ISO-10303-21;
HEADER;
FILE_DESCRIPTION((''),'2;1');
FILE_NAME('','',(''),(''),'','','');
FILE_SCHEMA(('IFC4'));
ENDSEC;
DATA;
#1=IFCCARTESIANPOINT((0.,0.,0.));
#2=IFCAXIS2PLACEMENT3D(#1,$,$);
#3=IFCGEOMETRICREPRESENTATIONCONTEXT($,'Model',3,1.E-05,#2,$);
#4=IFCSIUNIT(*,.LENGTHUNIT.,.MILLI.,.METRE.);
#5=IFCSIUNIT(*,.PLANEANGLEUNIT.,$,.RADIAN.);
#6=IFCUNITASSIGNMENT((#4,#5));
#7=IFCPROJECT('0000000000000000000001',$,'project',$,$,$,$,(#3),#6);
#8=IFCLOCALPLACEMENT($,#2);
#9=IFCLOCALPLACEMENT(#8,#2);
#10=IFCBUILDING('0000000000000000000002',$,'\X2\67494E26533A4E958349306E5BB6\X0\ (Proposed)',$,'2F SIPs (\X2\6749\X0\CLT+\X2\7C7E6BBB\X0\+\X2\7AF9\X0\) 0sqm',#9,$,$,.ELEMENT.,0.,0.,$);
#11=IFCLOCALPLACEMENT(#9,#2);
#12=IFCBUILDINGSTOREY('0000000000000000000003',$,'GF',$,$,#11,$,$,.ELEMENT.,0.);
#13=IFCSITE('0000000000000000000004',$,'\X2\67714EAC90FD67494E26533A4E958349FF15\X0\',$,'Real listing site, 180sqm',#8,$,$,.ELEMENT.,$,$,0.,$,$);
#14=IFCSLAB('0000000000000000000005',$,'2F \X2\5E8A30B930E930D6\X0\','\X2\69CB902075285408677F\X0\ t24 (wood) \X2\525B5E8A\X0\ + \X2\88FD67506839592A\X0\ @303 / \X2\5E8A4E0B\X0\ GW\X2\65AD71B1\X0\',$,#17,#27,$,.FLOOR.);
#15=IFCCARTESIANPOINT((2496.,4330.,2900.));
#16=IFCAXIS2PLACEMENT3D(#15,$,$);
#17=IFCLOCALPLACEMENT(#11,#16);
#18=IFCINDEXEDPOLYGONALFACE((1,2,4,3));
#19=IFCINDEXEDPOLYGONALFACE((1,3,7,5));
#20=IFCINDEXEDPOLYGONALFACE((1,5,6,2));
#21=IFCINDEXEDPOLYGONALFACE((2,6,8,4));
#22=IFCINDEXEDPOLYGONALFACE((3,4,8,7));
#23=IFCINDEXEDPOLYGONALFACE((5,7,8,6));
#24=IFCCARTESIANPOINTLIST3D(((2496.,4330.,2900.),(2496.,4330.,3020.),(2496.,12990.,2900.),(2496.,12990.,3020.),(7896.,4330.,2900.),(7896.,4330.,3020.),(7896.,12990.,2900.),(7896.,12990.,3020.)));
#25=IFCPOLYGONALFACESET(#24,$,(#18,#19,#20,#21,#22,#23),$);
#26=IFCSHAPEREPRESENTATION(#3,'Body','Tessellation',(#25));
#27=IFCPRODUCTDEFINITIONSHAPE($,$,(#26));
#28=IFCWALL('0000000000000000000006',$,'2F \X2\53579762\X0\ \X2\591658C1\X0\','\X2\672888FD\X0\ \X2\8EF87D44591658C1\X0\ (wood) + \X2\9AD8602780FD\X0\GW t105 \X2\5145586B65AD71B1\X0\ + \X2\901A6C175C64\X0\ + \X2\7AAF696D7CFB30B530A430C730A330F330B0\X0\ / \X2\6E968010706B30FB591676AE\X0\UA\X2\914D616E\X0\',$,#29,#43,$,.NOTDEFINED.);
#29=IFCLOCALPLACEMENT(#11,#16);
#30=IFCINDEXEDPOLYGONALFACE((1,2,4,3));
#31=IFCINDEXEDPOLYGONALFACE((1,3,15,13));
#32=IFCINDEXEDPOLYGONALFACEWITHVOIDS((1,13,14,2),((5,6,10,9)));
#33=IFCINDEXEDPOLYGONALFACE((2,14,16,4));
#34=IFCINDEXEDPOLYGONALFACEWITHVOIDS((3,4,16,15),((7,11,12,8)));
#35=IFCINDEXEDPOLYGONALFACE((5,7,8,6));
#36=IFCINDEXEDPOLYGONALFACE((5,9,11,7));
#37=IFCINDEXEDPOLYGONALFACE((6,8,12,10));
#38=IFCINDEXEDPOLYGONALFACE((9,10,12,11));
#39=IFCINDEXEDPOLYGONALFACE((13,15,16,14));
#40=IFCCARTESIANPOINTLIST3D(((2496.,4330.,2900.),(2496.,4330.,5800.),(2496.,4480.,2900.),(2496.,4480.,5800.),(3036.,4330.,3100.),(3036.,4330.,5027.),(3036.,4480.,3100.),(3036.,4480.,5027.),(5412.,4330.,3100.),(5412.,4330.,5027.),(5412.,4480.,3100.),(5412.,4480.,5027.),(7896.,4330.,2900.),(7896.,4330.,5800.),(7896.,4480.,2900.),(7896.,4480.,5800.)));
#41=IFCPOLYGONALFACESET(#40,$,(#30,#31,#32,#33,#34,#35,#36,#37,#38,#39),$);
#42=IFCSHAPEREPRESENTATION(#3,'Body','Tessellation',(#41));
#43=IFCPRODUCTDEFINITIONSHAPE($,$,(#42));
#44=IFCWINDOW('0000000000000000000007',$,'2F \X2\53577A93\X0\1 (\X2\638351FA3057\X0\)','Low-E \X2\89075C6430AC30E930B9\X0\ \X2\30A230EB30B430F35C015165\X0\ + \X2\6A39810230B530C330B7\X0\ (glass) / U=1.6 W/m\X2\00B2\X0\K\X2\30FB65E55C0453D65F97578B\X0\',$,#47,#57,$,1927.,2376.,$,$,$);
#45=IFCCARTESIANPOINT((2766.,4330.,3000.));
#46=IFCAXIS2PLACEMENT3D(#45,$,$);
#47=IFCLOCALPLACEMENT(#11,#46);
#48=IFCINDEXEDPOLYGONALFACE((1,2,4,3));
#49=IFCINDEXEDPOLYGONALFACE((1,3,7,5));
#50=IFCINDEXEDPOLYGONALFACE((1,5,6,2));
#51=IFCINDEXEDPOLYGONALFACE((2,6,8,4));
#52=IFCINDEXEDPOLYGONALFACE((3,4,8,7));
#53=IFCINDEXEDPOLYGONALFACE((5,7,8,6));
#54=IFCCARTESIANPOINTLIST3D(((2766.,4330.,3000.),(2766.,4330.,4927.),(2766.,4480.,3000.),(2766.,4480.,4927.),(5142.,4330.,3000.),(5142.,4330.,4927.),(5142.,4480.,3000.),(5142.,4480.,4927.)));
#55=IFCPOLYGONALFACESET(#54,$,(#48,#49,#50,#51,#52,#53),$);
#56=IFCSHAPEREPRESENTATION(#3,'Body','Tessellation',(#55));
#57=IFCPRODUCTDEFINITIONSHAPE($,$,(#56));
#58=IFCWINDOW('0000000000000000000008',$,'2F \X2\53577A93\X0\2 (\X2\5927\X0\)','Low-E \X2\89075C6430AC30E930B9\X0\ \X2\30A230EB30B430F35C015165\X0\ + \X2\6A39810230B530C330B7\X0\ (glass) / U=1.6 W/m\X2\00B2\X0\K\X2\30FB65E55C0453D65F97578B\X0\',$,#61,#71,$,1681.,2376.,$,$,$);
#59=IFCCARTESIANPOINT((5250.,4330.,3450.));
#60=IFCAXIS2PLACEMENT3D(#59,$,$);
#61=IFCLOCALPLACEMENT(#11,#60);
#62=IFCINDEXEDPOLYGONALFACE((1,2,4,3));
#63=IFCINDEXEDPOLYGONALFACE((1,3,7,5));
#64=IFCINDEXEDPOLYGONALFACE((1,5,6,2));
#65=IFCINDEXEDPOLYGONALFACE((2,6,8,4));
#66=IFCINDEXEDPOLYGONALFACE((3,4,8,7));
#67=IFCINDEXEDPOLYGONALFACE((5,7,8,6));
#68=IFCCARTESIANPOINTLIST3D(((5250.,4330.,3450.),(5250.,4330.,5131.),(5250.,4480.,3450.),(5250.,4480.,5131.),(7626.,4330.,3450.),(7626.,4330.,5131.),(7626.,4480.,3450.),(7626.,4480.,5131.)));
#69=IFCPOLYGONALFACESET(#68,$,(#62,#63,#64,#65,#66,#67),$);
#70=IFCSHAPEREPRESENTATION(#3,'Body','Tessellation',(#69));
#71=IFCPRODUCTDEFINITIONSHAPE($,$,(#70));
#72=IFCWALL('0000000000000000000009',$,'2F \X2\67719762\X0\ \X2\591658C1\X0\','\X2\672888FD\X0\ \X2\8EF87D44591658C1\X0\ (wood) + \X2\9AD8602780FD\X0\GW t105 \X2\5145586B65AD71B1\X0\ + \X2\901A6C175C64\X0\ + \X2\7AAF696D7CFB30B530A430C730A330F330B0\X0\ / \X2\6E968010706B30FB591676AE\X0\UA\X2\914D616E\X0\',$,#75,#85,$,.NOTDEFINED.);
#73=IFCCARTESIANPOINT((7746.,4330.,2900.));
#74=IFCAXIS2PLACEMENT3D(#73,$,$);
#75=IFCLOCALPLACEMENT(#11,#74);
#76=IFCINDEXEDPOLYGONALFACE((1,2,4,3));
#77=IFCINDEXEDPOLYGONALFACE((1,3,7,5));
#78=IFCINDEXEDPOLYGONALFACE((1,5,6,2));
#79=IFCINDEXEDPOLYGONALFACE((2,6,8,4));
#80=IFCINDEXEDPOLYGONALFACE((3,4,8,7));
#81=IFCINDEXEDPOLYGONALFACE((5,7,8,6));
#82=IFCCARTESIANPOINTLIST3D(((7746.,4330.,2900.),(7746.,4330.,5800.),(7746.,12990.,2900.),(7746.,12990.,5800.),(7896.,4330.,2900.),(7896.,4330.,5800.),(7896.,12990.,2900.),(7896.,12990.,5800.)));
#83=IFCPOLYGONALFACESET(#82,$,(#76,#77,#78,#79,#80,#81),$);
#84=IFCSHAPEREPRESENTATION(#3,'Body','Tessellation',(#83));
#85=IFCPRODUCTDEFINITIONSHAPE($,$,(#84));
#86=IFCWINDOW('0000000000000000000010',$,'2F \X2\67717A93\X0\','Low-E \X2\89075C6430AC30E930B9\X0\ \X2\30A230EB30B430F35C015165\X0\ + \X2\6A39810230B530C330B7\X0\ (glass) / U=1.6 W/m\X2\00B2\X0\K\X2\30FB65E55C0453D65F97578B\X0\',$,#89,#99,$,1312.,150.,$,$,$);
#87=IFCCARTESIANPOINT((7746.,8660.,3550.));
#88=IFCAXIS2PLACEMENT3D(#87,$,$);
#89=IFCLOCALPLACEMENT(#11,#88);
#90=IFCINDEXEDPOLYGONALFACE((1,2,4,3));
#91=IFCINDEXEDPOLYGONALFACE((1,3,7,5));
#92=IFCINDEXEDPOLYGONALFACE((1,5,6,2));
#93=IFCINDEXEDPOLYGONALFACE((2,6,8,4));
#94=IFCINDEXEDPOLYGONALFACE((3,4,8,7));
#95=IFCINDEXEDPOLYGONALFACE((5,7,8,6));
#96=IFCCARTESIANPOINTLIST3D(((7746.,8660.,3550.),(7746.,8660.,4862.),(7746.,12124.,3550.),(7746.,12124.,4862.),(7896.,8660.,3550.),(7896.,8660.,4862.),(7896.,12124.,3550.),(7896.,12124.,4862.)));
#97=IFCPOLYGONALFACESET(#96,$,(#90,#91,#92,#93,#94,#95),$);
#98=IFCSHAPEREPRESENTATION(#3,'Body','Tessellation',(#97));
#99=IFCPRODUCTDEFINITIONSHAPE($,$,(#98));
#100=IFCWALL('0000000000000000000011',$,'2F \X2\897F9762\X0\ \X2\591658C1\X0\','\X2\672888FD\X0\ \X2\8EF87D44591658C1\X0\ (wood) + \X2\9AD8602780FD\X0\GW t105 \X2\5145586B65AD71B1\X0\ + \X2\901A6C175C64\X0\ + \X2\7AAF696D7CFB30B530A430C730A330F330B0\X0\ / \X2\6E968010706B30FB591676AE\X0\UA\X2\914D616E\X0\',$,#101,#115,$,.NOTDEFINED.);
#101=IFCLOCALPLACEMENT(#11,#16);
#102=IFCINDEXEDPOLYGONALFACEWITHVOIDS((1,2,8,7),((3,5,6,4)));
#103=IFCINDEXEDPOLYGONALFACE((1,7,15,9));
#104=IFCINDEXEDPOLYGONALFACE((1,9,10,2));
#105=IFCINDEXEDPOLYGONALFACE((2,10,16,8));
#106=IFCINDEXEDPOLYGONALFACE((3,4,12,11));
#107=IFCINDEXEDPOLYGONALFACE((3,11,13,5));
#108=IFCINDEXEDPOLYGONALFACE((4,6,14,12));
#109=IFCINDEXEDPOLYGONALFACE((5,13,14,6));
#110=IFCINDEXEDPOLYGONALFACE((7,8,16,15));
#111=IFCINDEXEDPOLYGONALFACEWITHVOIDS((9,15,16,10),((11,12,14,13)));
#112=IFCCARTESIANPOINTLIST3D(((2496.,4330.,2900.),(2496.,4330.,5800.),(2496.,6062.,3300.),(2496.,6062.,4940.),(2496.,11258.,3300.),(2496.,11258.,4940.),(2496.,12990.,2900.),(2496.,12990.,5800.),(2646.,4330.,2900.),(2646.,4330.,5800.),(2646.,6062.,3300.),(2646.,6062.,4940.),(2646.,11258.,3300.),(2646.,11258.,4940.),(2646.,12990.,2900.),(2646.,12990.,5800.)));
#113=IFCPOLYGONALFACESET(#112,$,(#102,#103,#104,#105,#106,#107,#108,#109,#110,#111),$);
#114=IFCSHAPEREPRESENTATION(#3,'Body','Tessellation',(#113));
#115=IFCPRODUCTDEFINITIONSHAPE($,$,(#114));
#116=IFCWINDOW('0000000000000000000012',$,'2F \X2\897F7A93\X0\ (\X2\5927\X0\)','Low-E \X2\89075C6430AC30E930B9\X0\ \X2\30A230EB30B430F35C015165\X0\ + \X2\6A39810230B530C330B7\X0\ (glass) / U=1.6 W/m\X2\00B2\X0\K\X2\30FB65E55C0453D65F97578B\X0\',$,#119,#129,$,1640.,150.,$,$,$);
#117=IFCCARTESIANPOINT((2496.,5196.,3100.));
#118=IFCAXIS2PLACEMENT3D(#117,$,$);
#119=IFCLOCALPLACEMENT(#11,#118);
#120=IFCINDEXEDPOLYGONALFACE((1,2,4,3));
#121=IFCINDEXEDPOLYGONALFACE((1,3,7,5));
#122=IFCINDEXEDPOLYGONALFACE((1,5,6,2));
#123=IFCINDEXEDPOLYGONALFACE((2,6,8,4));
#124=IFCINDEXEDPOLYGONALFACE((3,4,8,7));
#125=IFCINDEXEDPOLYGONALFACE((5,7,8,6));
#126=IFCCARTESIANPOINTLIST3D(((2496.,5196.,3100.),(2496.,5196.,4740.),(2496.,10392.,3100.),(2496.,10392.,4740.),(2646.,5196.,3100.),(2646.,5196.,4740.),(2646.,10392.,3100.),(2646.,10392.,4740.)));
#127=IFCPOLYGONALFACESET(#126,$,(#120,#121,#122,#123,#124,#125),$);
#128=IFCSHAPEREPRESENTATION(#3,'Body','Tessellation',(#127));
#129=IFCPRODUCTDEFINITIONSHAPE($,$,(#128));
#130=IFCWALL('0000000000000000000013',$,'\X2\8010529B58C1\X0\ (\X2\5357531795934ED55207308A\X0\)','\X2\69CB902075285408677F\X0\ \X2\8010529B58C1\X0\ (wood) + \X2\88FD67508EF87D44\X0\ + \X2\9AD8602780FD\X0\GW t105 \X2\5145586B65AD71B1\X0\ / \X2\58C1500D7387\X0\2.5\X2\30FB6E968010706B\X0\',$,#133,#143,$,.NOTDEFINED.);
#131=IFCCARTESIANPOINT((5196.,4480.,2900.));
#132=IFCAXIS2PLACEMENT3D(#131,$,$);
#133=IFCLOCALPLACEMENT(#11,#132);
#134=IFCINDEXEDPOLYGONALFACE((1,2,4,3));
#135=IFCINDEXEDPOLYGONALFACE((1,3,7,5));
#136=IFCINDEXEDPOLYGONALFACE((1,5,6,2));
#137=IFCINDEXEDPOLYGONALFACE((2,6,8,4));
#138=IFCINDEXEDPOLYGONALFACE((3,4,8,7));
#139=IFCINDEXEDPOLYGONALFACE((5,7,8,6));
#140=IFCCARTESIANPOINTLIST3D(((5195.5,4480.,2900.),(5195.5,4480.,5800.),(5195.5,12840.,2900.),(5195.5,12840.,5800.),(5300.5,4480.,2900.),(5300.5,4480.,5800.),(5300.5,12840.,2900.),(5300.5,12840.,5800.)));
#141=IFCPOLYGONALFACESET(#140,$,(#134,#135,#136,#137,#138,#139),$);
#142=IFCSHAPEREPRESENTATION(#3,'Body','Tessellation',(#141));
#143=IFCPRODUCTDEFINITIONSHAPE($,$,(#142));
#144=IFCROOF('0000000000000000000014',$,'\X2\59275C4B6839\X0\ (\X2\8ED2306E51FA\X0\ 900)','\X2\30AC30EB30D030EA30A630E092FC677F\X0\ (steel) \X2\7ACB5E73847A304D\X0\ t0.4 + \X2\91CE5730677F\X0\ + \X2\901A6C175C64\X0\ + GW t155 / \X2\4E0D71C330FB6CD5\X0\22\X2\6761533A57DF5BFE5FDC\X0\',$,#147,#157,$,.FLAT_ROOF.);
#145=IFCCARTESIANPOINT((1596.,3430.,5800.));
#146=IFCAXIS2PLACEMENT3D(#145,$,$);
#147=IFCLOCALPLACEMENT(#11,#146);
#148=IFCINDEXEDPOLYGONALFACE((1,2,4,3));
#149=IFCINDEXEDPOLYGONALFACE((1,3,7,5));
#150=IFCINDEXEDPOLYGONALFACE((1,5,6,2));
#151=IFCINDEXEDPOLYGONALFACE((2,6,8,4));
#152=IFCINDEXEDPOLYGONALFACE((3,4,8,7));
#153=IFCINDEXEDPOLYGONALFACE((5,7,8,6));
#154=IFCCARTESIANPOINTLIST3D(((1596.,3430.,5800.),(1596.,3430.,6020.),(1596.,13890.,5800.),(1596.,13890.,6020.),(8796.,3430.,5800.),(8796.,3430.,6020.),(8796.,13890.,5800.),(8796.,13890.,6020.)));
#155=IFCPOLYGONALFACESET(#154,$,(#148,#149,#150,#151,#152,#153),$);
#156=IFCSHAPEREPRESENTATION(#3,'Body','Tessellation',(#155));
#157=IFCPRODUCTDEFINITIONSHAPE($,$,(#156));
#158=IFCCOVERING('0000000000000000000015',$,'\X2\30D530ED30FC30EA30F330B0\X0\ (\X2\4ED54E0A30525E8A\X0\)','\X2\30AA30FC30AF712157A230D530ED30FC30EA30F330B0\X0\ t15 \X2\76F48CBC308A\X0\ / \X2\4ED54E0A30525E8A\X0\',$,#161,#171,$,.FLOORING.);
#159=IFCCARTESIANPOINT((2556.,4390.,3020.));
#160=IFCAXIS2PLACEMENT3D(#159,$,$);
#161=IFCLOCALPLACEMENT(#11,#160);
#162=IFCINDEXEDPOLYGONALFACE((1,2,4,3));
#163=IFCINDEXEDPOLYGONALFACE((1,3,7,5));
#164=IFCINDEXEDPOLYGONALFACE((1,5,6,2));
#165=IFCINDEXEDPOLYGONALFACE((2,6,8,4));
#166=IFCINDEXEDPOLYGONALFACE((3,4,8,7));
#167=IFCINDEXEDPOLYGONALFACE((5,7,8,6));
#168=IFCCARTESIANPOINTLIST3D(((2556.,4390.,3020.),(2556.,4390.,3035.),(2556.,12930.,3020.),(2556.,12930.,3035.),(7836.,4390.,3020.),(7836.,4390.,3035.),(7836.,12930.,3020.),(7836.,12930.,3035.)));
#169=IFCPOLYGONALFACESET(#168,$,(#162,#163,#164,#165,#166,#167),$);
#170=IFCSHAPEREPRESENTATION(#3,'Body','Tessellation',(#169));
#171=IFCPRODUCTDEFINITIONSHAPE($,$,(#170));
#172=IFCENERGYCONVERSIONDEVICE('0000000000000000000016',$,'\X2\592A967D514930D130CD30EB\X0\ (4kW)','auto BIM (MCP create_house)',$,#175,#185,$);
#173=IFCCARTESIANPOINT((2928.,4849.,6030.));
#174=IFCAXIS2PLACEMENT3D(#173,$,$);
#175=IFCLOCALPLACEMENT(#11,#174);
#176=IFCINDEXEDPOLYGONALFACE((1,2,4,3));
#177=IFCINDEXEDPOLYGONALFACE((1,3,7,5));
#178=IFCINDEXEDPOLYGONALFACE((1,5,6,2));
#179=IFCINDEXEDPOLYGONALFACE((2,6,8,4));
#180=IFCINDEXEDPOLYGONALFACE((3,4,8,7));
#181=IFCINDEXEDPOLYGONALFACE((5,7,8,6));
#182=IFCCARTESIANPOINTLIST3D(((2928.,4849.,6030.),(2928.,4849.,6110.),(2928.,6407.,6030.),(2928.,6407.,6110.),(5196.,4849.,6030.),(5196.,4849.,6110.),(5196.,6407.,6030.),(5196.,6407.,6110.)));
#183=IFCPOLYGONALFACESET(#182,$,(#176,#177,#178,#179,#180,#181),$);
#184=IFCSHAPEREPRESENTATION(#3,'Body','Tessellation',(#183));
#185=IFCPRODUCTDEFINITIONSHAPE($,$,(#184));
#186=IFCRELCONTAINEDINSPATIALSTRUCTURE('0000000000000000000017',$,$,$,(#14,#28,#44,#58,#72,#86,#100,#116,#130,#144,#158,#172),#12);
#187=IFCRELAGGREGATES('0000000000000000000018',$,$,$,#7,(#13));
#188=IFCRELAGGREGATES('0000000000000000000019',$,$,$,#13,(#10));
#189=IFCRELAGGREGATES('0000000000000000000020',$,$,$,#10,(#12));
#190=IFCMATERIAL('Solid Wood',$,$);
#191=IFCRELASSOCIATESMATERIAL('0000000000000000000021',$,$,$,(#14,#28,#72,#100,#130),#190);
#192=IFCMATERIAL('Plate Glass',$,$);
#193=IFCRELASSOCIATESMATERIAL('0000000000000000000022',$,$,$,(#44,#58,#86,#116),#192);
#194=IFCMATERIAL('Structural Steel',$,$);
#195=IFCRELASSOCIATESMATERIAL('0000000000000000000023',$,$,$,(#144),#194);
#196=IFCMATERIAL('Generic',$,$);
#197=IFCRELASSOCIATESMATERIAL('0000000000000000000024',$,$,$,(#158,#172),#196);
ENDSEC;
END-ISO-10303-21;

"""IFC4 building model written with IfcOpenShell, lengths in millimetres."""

from ifc_helpers import new_model, si_unit, frame, frame_2d, origin, place, context, project, spatial, rectangle, extrude, material, element, fill, save


model = new_model("IFC4")

# Units and contexts
model_context = context("Model", 3, precision=1e-05, world=origin())
ifc_project = project(units=[si_unit("LENGTHUNIT", "METRE", prefix="MILLI"), si_unit("PLANEANGLEUNIT", "RADIAN")], contexts=[model_context])

# Site, building, storey
site_placement = place(None, origin())
site = spatial("IfcSite", under=ifc_project, at=site_placement, Name="東京都杉並区井草５", ObjectType="Real listing site, 180sqm", CompositionType="ELEMENT", RefElevation=0.0)
building_placement = place(site_placement, origin())
building = spatial("IfcBuilding", under=site, at=building_placement, Name="杉並区井草の家 (Proposed)", ObjectType="2F SIPs (杉CLT+籾殻+竹) 0sqm", CompositionType="ELEMENT", ElevationOfRefHeight=0.0, ElevationOfTerrain=0.0)
storey_placement = place(building_placement, origin())
storey = spatial("IfcBuildingStorey", under=building, at=storey_placement, Name="GF", CompositionType="ELEMENT", Elevation=0.0)

# Slab
ifc_material_1 = material(Name="Solid Wood")
slab_placement = place(storey_placement, frame((2496.0, 4330.0, 2900.0)))
element("IfcSlab", 1, at=slab_placement, inside=storey, material=ifc_material_1, Name="2F 床スラブ", Description="構造用合板 t24 (wood) 剛床 + 製材根太 @303 / 床下 GW断熱", PredefinedType="FLOOR", context=model_context, shape_type="SweptSolid", body=[
    extrude(rectangle(XDim=5400.0, YDim=8660.0, at=frame_2d((2700.0, 4330.0))), frame((2496.0, 4330.0, 2900.0)), (0.0, 0.0, 1.0), 120.0),
])

# Wall, openings, windows
wall_1_placement = place(storey_placement, frame((2496.0, 4330.0, 2900.0)))
wall_1 = element("IfcWall", 2, at=wall_1_placement, inside=storey, material=ifc_material_1, Name="2F 南面 外壁", Description="木製 軸組外壁 (wood) + 高性能GW t105 充填断熱 + 通気層 + 窯業系サイディング / 準耐火・外皮UA配慮", PredefinedType="NOTDEFINED", context=model_context, shape_type="SweptSolid", body=[
    extrude(rectangle(XDim=5400.0, YDim=150.0, at=frame_2d((2700.0, 75.0))), frame((2496.0, 4330.0, 2900.0)), (0.0, 0.0, 1.0), 2900.0),
])
opening_1_placement = place(storey_placement, frame((2766.0, 4330.0, 3000.0)))
opening_1 = element("IfcOpeningElement", 3, at=opening_1_placement, cuts=wall_1, PredefinedType="NOTDEFINED", context=model_context, shape_type="SweptSolid", body=[
    extrude(rectangle(XDim=2376.0, YDim=150.0, at=frame_2d((1188.0, 75.0))), frame((2766.0, 4330.0, 3000.0)), (0.0, 0.0, 1.0), 1927.0),
])
opening_2_placement = place(storey_placement, frame((5250.0, 4330.0, 3450.0)))
opening_2 = element("IfcOpeningElement", 4, at=opening_2_placement, cuts=wall_1, PredefinedType="NOTDEFINED", context=model_context, shape_type="SweptSolid", body=[
    extrude(rectangle(XDim=2376.0, YDim=150.0, at=frame_2d((1188.0, 75.0))), frame((5250.0, 4330.0, 3450.0)), (0.0, 0.0, 1.0), 1681.0),
])
ifc_material_2 = material(Name="Plate Glass")
window_1_placement = place(storey_placement, frame((2766.0, 4330.0, 3000.0)))
window_1 = element("IfcWindow", 5, at=window_1_placement, inside=storey, material=ifc_material_2, Name="2F 南窓1 (掃出し)", Description="Low-E 複層ガラス アルゴン封入 + 樹脂サッシ (glass) / U=1.6 W/m²K・日射取得型", OverallHeight=1927.0, OverallWidth=2376.0, context=model_context, shape_type="SweptSolid", body=[
    extrude(rectangle(XDim=2376.0, YDim=150.0, at=frame_2d((1188.0, 75.0))), frame((2766.0, 4330.0, 3000.0)), (0.0, 0.0, 1.0), 1927.0),
])
fill(opening_1, window_1)
window_2_placement = place(storey_placement, frame((5250.0, 4330.0, 3450.0)))
window_2 = element("IfcWindow", 6, at=window_2_placement, inside=storey, material=ifc_material_2, Name="2F 南窓2 (大)", Description="Low-E 複層ガラス アルゴン封入 + 樹脂サッシ (glass) / U=1.6 W/m²K・日射取得型", OverallHeight=1681.0, OverallWidth=2376.0, context=model_context, shape_type="SweptSolid", body=[
    extrude(rectangle(XDim=2376.0, YDim=150.0, at=frame_2d((1188.0, 75.0))), frame((5250.0, 4330.0, 3450.0)), (0.0, 0.0, 1.0), 1681.0),
])
fill(opening_2, window_2)

# Walls, openings, windows
wall_2_placement = place(storey_placement, frame((7746.0, 4330.0, 2900.0)))
wall_2 = element("IfcWall", 7, at=wall_2_placement, inside=storey, material=ifc_material_1, Name="2F 東面 外壁", Description="木製 軸組外壁 (wood) + 高性能GW t105 充填断熱 + 通気層 + 窯業系サイディング / 準耐火・外皮UA配慮", PredefinedType="NOTDEFINED", context=model_context, shape_type="SweptSolid", body=[
    extrude(rectangle(XDim=150.0, YDim=8660.0, at=frame_2d((75.0, 4330.0))), frame((7746.0, 4330.0, 2900.0)), (0.0, 0.0, 1.0), 2900.0),
])
opening_3_placement = place(storey_placement, frame((7746.0, 8660.0, 3550.0)))
opening_3 = element("IfcOpeningElement", 8, at=opening_3_placement, cuts=wall_2, PredefinedType="NOTDEFINED", context=model_context, shape_type="SweptSolid", body=[
    extrude(rectangle(XDim=150.0, YDim=3464.0, at=frame_2d((75.0, 1732.0))), frame((7746.0, 8660.0, 3550.0)), (0.0, 0.0, 1.0), 1312.0),
])
window_3_placement = place(storey_placement, frame((7746.0, 8660.0, 3550.0)))
window_3 = element("IfcWindow", 9, at=window_3_placement, inside=storey, material=ifc_material_2, Name="2F 東窓", Description="Low-E 複層ガラス アルゴン封入 + 樹脂サッシ (glass) / U=1.6 W/m²K・日射取得型", OverallHeight=1312.0, OverallWidth=150.0, context=model_context, shape_type="SweptSolid", body=[
    extrude(rectangle(XDim=150.0, YDim=3464.0, at=frame_2d((75.0, 1732.0))), frame((7746.0, 8660.0, 3550.0)), (0.0, 0.0, 1.0), 1312.0),
])
fill(opening_3, window_3)
wall_3_placement = place(storey_placement, frame((2496.0, 4330.0, 2900.0)))
wall_3 = element("IfcWall", 10, at=wall_3_placement, inside=storey, material=ifc_material_1, Name="2F 西面 外壁", Description="木製 軸組外壁 (wood) + 高性能GW t105 充填断熱 + 通気層 + 窯業系サイディング / 準耐火・外皮UA配慮", PredefinedType="NOTDEFINED", context=model_context, shape_type="SweptSolid", body=[
    extrude(rectangle(XDim=150.0, YDim=8660.0, at=frame_2d((75.0, 4330.0))), frame((2496.0, 4330.0, 2900.0)), (0.0, 0.0, 1.0), 2900.0),
])
opening_4_placement = place(storey_placement, frame((2496.0, 5196.0, 3100.0)))
opening_4 = element("IfcOpeningElement", 11, at=opening_4_placement, cuts=wall_3, PredefinedType="NOTDEFINED", context=model_context, shape_type="SweptSolid", body=[
    extrude(rectangle(XDim=150.0, YDim=5196.0, at=frame_2d((75.0, 2598.0))), frame((2496.0, 5196.0, 3100.0)), (0.0, 0.0, 1.0), 1640.0),
])
window_4_placement = place(storey_placement, frame((2496.0, 5196.0, 3100.0)))
window_4 = element("IfcWindow", 12, at=window_4_placement, inside=storey, material=ifc_material_2, Name="2F 西窓 (大)", Description="Low-E 複層ガラス アルゴン封入 + 樹脂サッシ (glass) / U=1.6 W/m²K・日射取得型", OverallHeight=1640.0, OverallWidth=150.0, context=model_context, shape_type="SweptSolid", body=[
    extrude(rectangle(XDim=150.0, YDim=5196.0, at=frame_2d((75.0, 2598.0))), frame((2496.0, 5196.0, 3100.0)), (0.0, 0.0, 1.0), 1640.0),
])
fill(opening_4, window_4)

# Wall
wall_4_placement = place(storey_placement, frame((5196.0, 4480.0, 2900.0)))
element("IfcWall", 13, at=wall_4_placement, inside=storey, material=ifc_material_1, Name="耐力壁 (南北間仕切り)", Description="構造用合板 耐力壁 (wood) + 製材軸組 + 高性能GW t105 充填断熱 / 壁倍率2.5・準耐火", PredefinedType="NOTDEFINED", context=model_context, shape_type="SweptSolid", body=[
    extrude(rectangle(XDim=105.0, YDim=8360.0, at=frame_2d((52.0, 4180.0))), frame((5196.0, 4480.0, 2900.0)), (0.0, 0.0, 1.0), 2900.0),
])

# Roof
ifc_material_3 = material(Name="Structural Steel")
roof_placement = place(storey_placement, frame((1596.0, 3430.0, 5800.0)))
element("IfcRoof", 14, at=roof_placement, inside=storey, material=ifc_material_3, Name="大屋根 (軒の出 900)", Description="ガルバリウム鋼板 (steel) 立平葺き t0.4 + 野地板 + 通気層 + GW t155 / 不燃・法22条区域対応", PredefinedType="FLAT_ROOF", context=model_context, shape_type="SweptSolid", body=[
    extrude(rectangle(XDim=7200.0, YDim=10460.0, at=frame_2d((3600.0, 5230.0))), frame((1596.0, 3430.0, 5800.0)), (0.0, 0.0, 1.0), 220.0),
])

# Covering
ifc_material_4 = material(Name="Generic")
covering_placement = place(storey_placement, frame((2556.0, 4390.0, 3020.0)))
element("IfcCovering", 15, at=covering_placement, inside=storey, material=ifc_material_4, Name="フローリング (仕上げ床)", Description="オーク無垢フローリング t15 直貼り / 仕上げ床", PredefinedType="FLOORING", context=model_context, shape_type="SweptSolid", body=[
    extrude(rectangle(XDim=5280.0, YDim=8540.0, at=frame_2d((2640.0, 4270.0))), frame((2556.0, 4390.0, 3020.0)), (0.0, 0.0, 1.0), 15.0),
])

# Energy conversion device
energy_conversion_device_placement = place(storey_placement, frame((2928.0, 4849.0, 6030.0)))
element("IfcEnergyConversionDevice", 16, at=energy_conversion_device_placement, inside=storey, material=ifc_material_4, Name="太陽光パネル (4kW)", Description="auto BIM (MCP create_house)", context=model_context, shape_type="SweptSolid", body=[
    extrude(rectangle(XDim=2268.0, YDim=1558.0, at=frame_2d((1134.0, 779.0))), frame((2928.0, 4849.0, 6030.0)), (0.0, 0.0, 1.0), 80.0),
])

save(model, "model.ifc")
